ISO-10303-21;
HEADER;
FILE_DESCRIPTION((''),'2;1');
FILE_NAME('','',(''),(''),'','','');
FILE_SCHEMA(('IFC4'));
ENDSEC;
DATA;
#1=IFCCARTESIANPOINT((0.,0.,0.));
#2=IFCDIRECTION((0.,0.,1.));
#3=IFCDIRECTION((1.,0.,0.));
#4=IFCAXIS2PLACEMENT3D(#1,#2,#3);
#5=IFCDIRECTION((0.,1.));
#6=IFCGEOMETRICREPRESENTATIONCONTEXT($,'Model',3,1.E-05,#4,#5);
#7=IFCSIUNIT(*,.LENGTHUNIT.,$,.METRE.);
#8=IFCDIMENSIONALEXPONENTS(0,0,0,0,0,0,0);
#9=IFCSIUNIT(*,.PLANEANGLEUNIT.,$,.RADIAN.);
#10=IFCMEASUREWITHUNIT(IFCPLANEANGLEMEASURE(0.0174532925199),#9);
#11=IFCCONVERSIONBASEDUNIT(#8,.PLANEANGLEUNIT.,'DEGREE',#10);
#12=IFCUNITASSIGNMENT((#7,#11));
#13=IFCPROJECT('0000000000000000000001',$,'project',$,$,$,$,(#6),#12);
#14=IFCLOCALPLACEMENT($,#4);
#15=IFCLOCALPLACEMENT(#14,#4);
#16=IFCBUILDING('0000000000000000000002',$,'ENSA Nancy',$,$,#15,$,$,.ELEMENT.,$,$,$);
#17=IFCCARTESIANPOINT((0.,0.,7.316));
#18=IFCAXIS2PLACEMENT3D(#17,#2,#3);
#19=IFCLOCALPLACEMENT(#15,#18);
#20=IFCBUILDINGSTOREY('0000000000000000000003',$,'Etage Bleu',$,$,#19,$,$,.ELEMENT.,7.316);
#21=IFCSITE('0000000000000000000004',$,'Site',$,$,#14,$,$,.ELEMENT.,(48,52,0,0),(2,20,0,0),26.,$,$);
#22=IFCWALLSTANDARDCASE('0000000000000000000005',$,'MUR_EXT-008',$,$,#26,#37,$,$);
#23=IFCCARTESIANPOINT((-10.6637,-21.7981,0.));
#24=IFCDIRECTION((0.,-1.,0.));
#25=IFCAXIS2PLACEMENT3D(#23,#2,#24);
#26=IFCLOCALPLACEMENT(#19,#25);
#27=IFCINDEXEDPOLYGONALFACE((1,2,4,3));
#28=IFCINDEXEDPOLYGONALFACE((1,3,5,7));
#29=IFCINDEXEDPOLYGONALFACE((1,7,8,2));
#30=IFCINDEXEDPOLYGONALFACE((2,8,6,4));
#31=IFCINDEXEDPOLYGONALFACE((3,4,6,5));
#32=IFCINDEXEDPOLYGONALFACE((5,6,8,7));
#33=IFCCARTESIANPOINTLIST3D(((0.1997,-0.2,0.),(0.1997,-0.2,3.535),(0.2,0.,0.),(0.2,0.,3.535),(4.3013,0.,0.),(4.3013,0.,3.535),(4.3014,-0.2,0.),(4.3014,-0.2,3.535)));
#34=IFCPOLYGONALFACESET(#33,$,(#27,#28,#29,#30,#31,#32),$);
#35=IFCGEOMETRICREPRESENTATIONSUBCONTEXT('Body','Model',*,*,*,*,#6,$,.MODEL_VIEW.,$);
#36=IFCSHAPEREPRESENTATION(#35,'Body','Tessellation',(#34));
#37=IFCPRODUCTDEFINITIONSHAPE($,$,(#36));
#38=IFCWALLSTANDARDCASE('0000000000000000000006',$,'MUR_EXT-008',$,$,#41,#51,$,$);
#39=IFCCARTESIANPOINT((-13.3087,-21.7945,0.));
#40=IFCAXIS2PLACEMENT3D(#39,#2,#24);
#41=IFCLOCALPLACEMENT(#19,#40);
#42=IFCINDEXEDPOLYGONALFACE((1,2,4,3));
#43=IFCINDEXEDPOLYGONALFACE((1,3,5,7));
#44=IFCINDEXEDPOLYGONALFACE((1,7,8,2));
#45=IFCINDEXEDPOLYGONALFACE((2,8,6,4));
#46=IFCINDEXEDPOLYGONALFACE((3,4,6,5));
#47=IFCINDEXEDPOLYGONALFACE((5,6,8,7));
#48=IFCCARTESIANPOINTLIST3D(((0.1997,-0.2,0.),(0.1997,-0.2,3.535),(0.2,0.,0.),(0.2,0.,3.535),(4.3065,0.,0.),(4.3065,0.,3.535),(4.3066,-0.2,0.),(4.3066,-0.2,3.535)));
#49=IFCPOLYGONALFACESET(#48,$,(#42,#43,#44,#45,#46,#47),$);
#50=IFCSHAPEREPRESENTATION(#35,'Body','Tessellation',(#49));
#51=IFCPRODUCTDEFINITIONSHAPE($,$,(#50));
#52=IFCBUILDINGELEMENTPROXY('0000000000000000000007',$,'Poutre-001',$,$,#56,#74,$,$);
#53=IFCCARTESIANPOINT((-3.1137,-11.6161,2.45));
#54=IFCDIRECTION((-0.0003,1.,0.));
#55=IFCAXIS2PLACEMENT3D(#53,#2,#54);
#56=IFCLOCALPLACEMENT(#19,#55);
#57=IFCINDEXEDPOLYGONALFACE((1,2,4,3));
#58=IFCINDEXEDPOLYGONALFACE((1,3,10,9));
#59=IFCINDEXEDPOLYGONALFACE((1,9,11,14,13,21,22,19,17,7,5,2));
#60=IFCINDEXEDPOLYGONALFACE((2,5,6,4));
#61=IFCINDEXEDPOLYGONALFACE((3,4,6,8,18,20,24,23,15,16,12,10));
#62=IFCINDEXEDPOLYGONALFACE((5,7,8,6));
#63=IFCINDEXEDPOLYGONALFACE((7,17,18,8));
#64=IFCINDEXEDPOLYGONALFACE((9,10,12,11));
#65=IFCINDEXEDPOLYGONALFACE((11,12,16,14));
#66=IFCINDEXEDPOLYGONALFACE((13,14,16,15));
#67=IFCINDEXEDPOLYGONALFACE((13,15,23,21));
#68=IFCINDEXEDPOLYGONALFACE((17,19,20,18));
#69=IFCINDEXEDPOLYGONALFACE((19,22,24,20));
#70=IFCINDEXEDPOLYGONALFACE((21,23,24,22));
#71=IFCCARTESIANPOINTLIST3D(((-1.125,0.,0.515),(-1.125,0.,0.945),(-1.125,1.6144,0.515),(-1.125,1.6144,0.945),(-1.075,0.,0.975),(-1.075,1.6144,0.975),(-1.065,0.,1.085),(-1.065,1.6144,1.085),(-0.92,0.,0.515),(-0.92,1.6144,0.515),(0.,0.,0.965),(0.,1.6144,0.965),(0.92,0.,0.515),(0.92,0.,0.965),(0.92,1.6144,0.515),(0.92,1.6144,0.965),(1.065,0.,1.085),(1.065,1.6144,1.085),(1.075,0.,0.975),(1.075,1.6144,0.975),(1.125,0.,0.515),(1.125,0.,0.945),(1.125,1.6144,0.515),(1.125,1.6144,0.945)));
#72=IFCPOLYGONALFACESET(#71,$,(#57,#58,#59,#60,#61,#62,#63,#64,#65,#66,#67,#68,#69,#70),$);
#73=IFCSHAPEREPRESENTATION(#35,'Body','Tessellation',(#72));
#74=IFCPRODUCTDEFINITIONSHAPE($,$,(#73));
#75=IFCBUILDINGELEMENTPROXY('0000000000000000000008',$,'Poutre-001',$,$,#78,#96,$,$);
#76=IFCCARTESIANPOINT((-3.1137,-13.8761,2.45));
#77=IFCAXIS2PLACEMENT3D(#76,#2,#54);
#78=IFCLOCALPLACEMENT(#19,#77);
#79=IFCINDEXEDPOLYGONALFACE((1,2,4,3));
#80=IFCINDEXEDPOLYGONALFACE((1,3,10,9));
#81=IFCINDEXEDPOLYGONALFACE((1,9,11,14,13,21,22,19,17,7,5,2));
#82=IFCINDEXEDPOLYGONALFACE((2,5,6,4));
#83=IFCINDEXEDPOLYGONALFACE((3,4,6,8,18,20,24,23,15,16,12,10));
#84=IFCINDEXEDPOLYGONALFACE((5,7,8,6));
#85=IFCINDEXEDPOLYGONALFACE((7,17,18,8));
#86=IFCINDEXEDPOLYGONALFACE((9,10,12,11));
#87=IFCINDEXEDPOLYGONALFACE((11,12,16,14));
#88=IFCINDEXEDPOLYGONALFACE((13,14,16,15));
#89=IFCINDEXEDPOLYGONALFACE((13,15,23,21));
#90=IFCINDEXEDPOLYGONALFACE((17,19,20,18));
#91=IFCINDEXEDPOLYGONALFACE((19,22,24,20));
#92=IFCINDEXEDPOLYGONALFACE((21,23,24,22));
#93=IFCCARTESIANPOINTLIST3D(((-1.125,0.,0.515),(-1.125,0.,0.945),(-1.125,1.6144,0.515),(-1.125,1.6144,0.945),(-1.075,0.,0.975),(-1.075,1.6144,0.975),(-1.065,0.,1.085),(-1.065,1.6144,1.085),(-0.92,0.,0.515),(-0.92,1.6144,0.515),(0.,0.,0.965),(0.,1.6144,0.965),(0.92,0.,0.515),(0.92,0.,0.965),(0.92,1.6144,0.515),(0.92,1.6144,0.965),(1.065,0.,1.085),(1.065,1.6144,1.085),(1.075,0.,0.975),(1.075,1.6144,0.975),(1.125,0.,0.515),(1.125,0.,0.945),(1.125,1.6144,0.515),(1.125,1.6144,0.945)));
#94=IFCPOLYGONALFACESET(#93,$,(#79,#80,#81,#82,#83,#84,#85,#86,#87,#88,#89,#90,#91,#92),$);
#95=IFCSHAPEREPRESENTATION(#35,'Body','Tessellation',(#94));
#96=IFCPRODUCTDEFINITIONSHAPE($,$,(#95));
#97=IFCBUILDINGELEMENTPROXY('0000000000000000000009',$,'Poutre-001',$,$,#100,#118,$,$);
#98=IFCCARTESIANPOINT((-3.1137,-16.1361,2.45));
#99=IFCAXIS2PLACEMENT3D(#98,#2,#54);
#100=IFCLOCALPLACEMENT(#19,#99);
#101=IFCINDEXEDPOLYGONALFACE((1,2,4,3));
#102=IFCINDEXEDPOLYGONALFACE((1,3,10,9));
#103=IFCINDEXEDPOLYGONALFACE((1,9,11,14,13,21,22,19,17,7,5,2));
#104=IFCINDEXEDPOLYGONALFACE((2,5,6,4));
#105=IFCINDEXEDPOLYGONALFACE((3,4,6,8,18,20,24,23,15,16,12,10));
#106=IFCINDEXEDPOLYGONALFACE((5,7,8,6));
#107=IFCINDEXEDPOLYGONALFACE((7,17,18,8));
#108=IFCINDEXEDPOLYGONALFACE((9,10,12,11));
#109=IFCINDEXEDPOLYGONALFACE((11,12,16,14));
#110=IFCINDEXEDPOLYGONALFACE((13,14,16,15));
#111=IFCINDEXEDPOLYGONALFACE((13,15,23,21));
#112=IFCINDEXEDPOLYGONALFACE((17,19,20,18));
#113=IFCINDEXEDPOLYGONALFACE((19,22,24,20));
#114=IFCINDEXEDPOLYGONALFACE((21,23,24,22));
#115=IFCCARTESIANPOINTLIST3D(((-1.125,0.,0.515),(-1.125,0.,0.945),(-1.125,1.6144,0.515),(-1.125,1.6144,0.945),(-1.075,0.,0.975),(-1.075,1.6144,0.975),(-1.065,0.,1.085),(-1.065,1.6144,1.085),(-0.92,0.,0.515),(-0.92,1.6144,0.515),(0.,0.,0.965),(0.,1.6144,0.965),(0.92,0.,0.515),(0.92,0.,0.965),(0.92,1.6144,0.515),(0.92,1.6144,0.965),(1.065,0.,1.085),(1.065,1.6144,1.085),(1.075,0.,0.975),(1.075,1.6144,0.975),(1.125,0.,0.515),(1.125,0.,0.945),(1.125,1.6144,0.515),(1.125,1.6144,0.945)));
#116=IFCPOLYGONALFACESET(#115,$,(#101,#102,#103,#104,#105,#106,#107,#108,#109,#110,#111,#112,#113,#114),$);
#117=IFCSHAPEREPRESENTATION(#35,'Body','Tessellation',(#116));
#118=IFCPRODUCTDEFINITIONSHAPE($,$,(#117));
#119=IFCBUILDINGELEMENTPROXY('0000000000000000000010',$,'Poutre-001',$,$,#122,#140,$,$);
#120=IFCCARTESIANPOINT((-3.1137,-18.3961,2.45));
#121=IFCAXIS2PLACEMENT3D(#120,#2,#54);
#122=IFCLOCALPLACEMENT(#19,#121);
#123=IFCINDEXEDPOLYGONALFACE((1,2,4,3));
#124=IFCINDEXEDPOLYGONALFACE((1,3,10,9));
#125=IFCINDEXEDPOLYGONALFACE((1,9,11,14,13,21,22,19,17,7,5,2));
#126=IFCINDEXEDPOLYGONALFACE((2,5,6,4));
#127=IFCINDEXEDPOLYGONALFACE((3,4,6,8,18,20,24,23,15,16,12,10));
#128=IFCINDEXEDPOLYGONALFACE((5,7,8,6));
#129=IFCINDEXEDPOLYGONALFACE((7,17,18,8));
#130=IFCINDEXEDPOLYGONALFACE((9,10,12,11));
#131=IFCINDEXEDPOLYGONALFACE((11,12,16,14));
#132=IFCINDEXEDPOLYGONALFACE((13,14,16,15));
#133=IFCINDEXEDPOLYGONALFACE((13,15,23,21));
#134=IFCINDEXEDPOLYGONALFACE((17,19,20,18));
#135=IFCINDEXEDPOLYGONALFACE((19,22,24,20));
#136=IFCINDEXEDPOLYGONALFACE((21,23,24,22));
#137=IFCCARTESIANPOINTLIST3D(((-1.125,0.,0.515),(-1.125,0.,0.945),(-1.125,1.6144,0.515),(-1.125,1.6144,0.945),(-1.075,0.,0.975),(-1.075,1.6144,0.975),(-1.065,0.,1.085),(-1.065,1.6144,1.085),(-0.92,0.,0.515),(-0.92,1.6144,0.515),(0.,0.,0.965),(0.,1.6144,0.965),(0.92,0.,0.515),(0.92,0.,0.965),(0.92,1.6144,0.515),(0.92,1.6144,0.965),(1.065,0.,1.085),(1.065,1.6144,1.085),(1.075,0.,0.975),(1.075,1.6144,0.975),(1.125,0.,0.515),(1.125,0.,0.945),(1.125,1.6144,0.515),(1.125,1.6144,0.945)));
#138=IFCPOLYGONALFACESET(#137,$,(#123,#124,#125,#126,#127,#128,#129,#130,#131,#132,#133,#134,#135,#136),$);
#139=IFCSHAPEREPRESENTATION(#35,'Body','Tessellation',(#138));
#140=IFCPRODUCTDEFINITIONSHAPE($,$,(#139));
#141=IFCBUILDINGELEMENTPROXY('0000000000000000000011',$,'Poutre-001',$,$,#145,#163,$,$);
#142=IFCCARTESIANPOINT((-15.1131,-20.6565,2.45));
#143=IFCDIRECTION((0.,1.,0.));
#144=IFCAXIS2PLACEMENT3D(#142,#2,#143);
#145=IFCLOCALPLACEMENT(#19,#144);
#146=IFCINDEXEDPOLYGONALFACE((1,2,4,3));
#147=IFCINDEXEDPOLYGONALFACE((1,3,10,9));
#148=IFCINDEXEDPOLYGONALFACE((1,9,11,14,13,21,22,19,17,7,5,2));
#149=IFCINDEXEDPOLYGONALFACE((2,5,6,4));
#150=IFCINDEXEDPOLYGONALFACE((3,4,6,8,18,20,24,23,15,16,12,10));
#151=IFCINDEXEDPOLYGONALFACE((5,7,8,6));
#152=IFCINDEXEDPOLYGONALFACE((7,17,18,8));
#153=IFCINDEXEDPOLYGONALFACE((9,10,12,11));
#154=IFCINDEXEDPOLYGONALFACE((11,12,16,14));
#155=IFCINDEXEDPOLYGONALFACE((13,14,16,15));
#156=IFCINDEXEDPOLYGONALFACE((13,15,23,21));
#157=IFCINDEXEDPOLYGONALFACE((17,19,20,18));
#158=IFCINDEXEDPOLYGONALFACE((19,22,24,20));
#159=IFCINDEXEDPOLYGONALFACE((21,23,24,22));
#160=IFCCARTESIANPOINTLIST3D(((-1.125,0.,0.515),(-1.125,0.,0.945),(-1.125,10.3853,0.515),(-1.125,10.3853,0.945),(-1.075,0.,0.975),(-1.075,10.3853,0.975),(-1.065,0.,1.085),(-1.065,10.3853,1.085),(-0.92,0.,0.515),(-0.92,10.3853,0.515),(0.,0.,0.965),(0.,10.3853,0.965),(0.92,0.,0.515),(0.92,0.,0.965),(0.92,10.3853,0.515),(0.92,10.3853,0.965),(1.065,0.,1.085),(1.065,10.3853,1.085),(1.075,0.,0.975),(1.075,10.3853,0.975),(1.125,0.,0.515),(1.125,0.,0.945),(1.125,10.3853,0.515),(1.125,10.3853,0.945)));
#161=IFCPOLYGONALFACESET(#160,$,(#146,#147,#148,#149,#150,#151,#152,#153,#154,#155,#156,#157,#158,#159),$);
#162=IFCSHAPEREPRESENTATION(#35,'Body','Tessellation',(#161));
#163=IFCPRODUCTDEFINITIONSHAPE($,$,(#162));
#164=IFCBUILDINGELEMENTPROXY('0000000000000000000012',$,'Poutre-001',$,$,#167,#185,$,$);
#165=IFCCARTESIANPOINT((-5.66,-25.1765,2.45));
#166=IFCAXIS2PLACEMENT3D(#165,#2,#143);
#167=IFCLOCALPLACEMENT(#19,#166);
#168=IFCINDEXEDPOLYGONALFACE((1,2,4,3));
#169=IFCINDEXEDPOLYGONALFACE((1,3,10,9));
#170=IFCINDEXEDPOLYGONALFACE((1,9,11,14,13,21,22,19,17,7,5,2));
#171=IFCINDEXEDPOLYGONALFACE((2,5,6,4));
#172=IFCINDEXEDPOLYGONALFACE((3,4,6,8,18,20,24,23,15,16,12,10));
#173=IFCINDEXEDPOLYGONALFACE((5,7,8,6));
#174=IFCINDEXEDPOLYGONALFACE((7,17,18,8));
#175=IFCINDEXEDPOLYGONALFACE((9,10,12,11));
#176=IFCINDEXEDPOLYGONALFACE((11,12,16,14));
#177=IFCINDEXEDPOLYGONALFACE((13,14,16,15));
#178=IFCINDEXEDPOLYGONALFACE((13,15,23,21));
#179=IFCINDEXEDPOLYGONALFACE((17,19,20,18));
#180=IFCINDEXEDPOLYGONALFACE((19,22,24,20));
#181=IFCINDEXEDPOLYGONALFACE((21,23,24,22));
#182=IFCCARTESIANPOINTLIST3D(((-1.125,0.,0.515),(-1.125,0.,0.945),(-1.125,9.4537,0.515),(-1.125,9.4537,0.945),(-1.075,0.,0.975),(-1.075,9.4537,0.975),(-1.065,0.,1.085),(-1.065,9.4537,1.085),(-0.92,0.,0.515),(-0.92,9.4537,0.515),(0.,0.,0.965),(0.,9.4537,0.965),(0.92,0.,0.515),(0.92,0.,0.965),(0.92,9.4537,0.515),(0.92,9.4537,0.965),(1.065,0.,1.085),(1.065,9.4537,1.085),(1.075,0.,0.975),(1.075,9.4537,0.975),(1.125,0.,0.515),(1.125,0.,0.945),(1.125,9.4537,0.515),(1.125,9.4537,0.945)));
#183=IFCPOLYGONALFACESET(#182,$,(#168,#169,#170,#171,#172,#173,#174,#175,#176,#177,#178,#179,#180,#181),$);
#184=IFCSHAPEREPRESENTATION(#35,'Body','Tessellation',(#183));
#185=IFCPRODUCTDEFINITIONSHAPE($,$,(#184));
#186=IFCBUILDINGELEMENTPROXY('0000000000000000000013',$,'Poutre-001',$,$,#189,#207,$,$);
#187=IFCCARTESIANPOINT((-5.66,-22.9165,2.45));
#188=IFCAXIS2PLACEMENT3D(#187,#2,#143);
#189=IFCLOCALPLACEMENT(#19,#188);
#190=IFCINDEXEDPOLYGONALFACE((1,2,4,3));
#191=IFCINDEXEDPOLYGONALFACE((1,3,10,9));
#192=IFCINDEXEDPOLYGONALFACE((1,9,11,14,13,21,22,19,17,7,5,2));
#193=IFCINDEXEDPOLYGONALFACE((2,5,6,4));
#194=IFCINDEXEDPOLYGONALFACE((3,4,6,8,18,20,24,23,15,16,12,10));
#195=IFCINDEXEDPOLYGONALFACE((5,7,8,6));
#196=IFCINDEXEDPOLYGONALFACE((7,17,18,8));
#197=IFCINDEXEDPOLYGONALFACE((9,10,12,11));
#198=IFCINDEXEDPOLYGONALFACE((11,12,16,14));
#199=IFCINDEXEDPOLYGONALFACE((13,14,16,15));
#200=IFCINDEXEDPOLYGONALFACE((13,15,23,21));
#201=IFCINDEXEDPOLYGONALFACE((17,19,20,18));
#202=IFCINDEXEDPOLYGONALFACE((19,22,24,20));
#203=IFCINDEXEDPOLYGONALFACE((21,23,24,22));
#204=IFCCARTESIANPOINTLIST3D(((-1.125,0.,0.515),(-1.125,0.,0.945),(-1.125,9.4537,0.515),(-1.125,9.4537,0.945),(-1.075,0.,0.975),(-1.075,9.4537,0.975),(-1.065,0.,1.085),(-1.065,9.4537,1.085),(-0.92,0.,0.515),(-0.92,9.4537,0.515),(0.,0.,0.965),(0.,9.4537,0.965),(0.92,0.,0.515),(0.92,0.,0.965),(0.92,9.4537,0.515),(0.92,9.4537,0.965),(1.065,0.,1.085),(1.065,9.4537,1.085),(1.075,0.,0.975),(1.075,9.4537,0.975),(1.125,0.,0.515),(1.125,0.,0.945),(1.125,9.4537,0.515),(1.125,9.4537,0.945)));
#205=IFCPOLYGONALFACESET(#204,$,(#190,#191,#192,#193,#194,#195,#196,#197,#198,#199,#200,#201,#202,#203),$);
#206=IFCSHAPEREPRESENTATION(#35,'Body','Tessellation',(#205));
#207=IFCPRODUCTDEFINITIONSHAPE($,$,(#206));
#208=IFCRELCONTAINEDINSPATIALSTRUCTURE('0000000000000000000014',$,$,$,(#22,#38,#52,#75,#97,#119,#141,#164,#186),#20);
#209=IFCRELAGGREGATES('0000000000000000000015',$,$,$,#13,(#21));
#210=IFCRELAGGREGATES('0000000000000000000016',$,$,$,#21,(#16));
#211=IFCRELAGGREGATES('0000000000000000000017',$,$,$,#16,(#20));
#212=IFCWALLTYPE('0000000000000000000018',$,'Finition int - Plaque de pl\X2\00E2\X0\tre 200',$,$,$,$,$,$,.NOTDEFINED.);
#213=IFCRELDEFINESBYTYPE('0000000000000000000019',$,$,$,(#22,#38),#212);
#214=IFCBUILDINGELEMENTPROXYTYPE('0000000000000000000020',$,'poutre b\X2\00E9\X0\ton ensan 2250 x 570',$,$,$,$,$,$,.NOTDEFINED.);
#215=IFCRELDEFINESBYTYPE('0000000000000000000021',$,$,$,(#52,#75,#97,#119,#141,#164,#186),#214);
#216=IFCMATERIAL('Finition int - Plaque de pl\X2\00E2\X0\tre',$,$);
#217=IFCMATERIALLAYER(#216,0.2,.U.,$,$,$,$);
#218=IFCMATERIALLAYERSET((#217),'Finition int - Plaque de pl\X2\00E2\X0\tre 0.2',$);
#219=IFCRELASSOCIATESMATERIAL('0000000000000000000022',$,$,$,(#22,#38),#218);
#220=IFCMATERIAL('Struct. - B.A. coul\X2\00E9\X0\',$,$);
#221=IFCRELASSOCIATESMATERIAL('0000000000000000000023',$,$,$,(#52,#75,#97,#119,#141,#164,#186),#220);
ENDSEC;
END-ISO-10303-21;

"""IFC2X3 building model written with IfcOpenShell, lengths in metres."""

from ifc_helpers import new_model, entity, si_unit, converted_unit, direction, frame, origin_with_axes, place, context, subcontext, project, spatial, polyline, outline, extrude, material, layer, layer_set, layer_usage, type_object, element, save


model = new_model("IFC2X3")

# Units and contexts
model_context = context("Model", 3, precision=1e-05, world=origin_with_axes(), true_north=direction((0.0, 1.0)))
body_context = subcontext(model_context, "Body", "Model", "MODEL_VIEW")
ifc_project = project(units=[si_unit("LENGTHUNIT", "METRE"), converted_unit("PLANEANGLEUNIT", "DEGREE", entity("IfcPlaneAngleMeasure", 0.0174532925199), si_unit("PLANEANGLEUNIT", "RADIAN"), dimensions=[0, 0, 0, 0, 0, 0, 0])], contexts=[model_context])

# Site, building, storey
site_placement = place(None, origin_with_axes())
site = spatial("IfcSite", under=ifc_project, at=site_placement, Name="Site", CompositionType="ELEMENT", RefLatitude=(48, 52, 0, 0), RefLongitude=(2, 20, 0, 0), RefElevation=26.0)
building_placement = place(site_placement, origin_with_axes())
building = spatial("IfcBuilding", under=site, at=building_placement, Name="ENSA Nancy", CompositionType="ELEMENT")
storey_placement = place(building_placement, frame((0.0, 0.0, 7.316), z_axis=(0.0, 0.0, 1.0), x_axis=(1.0, 0.0, 0.0)))
storey = spatial("IfcBuildingStorey", under=building, at=storey_placement, Name="Etage Bleu", CompositionType="ELEMENT", Elevation=7.316)

# Shared definitions
ifc_material_1 = material(Name="Finition int - Plaque de plâtre")
ifc_layer_1 = layer(ifc_material_1, 0.2, ventilated="UNKNOWN")
ifc_layer_set_1 = layer_set([ifc_layer_1], Name="Finition int - Plaque de plâtre 0.2")
wall_type_1 = type_object("IfcWallType", Name="Finition int - Plaque de plâtre 200", PredefinedType="NOTDEFINED")

# Walls
ifc_layer_usage_1 = layer_usage(ifc_layer_set_1, "AXIS2", "NEGATIVE", 0.0)
wall_1_placement = place(storey_placement, frame((-10.6637, -21.7981, 0.0), z_axis=(0.0, 0.0, 1.0), x_axis=(0.0, -1.0, 0.0)))
element("IfcWallStandardCase", 1, at=wall_1_placement, inside=storey, type_object=wall_type_1, material=ifc_layer_usage_1, Name="MUR_EXT-008", context=body_context, shape_type="SweptSolid", body=[
    extrude(outline(polyline([(0.1997, -0.2), (4.3014, -0.2), (4.3013, 0.0), (0.2, 0.0), (0.1997, -0.2)])), origin_with_axes(), (0.0, 0.0, 1.0), 3.535),
])
ifc_layer_usage_2 = layer_usage(ifc_layer_set_1, "AXIS2", "NEGATIVE", 0.0)
wall_2_placement = place(storey_placement, frame((-13.3087, -21.7945, 0.0), z_axis=(0.0, 0.0, 1.0), x_axis=(0.0, -1.0, 0.0)))
element("IfcWallStandardCase", 2, at=wall_2_placement, inside=storey, type_object=wall_type_1, material=ifc_layer_usage_2, Name="MUR_EXT-008", context=body_context, shape_type="SweptSolid", body=[
    extrude(outline(polyline([(0.1997, -0.2), (4.3066, -0.2), (4.3065, 0.0), (0.2, 0.0), (0.1997, -0.2)])), origin_with_axes(), (0.0, 0.0, 1.0), 3.535),
])

# Building element proxies
ifc_material_2 = material(Name="Struct. - B.A. coulé")
building_element_proxy_type_1 = type_object("IfcBuildingElementProxyType", Name="poutre béton ensan 2250 x 570", PredefinedType="NOTDEFINED")
for number, where, z_axis, x_axis, name in (
    (3, (-3.1137, -11.6161, 2.45), (0.0, 0.0, 1.0), (-0.0003, 1.0, 0.0), "Poutre-001"),
    (4, (-3.1137, -13.8761, 2.45), (0.0, 0.0, 1.0), (-0.0003, 1.0, 0.0), "Poutre-001"),
    (5, (-3.1137, -16.1361, 2.45), (0.0, 0.0, 1.0), (-0.0003, 1.0, 0.0), "Poutre-001"),
    (6, (-3.1137, -18.3961, 2.45), (0.0, 0.0, 1.0), (-0.0003, 1.0, 0.0), "Poutre-001"),
):
    element("IfcBuildingElementProxy", number, at=place(storey_placement, frame(where, z_axis=z_axis, x_axis=x_axis)), inside=storey, type_object=building_element_proxy_type_1, material=ifc_material_2, Name=name, context=body_context, shape_type="SweptSolid", body=[
        extrude(outline(polyline([(-1.065, 1.085), (-1.075, 0.975), (-1.125, 0.945), (-1.125, 0.515), (-0.92, 0.515), (0.0, 0.965), (0.92, 0.965), (0.92, 0.515), (1.125, 0.515), (1.125, 0.945), (1.075, 0.975), (1.065, 1.085), (-1.065, 1.085)])), frame((0.0, 1.6144, 0.0), z_axis=(0.0, -1.0, 0.0), x_axis=(1.0, 0.0, 0.0)), (0.0, 0.0, 1.0), 1.6144),
    ])
proxy_1_placement = place(storey_placement, frame((-15.1131, -20.6565, 2.45), z_axis=(0.0, 0.0, 1.0), x_axis=(0.0, 1.0, 0.0)))
element("IfcBuildingElementProxy", 7, at=proxy_1_placement, inside=storey, type_object=building_element_proxy_type_1, material=ifc_material_2, Name="Poutre-001", context=body_context, shape_type="SweptSolid", body=[
    extrude(outline(polyline([(-1.065, 1.085), (-1.075, 0.975), (-1.125, 0.945), (-1.125, 0.515), (-0.92, 0.515), (0.0, 0.965), (0.92, 0.965), (0.92, 0.515), (1.125, 0.515), (1.125, 0.945), (1.075, 0.975), (1.065, 1.085), (-1.065, 1.085)])), frame((0.0, 10.3853, 0.0), z_axis=(0.0, -1.0, 0.0), x_axis=(1.0, 0.0, 0.0)), (0.0, 0.0, 1.0), 10.3853),
])
for number, where, z_axis, x_axis, name in (
    (8, (-5.66, -25.1765, 2.45), (0.0, 0.0, 1.0), (0.0, 1.0, 0.0), "Poutre-001"),
    (9, (-5.66, -22.9165, 2.45), (0.0, 0.0, 1.0), (0.0, 1.0, 0.0), "Poutre-001"),
):
    element("IfcBuildingElementProxy", number, at=place(storey_placement, frame(where, z_axis=z_axis, x_axis=x_axis)), inside=storey, type_object=building_element_proxy_type_1, material=ifc_material_2, Name=name, context=body_context, shape_type="SweptSolid", body=[
        extrude(outline(polyline([(-1.065, 1.085), (-1.075, 0.975), (-1.125, 0.945), (-1.125, 0.515), (-0.92, 0.515), (0.0, 0.965), (0.92, 0.965), (0.92, 0.515), (1.125, 0.515), (1.125, 0.945), (1.075, 0.975), (1.065, 1.085), (-1.065, 1.085)])), frame((0.0, 9.4537, 0.0), z_axis=(0.0, -1.0, 0.0), x_axis=(1.0, 0.0, 0.0)), (0.0, 0.0, 1.0), 9.4537),
    ])

save(model, "model.ifc")
